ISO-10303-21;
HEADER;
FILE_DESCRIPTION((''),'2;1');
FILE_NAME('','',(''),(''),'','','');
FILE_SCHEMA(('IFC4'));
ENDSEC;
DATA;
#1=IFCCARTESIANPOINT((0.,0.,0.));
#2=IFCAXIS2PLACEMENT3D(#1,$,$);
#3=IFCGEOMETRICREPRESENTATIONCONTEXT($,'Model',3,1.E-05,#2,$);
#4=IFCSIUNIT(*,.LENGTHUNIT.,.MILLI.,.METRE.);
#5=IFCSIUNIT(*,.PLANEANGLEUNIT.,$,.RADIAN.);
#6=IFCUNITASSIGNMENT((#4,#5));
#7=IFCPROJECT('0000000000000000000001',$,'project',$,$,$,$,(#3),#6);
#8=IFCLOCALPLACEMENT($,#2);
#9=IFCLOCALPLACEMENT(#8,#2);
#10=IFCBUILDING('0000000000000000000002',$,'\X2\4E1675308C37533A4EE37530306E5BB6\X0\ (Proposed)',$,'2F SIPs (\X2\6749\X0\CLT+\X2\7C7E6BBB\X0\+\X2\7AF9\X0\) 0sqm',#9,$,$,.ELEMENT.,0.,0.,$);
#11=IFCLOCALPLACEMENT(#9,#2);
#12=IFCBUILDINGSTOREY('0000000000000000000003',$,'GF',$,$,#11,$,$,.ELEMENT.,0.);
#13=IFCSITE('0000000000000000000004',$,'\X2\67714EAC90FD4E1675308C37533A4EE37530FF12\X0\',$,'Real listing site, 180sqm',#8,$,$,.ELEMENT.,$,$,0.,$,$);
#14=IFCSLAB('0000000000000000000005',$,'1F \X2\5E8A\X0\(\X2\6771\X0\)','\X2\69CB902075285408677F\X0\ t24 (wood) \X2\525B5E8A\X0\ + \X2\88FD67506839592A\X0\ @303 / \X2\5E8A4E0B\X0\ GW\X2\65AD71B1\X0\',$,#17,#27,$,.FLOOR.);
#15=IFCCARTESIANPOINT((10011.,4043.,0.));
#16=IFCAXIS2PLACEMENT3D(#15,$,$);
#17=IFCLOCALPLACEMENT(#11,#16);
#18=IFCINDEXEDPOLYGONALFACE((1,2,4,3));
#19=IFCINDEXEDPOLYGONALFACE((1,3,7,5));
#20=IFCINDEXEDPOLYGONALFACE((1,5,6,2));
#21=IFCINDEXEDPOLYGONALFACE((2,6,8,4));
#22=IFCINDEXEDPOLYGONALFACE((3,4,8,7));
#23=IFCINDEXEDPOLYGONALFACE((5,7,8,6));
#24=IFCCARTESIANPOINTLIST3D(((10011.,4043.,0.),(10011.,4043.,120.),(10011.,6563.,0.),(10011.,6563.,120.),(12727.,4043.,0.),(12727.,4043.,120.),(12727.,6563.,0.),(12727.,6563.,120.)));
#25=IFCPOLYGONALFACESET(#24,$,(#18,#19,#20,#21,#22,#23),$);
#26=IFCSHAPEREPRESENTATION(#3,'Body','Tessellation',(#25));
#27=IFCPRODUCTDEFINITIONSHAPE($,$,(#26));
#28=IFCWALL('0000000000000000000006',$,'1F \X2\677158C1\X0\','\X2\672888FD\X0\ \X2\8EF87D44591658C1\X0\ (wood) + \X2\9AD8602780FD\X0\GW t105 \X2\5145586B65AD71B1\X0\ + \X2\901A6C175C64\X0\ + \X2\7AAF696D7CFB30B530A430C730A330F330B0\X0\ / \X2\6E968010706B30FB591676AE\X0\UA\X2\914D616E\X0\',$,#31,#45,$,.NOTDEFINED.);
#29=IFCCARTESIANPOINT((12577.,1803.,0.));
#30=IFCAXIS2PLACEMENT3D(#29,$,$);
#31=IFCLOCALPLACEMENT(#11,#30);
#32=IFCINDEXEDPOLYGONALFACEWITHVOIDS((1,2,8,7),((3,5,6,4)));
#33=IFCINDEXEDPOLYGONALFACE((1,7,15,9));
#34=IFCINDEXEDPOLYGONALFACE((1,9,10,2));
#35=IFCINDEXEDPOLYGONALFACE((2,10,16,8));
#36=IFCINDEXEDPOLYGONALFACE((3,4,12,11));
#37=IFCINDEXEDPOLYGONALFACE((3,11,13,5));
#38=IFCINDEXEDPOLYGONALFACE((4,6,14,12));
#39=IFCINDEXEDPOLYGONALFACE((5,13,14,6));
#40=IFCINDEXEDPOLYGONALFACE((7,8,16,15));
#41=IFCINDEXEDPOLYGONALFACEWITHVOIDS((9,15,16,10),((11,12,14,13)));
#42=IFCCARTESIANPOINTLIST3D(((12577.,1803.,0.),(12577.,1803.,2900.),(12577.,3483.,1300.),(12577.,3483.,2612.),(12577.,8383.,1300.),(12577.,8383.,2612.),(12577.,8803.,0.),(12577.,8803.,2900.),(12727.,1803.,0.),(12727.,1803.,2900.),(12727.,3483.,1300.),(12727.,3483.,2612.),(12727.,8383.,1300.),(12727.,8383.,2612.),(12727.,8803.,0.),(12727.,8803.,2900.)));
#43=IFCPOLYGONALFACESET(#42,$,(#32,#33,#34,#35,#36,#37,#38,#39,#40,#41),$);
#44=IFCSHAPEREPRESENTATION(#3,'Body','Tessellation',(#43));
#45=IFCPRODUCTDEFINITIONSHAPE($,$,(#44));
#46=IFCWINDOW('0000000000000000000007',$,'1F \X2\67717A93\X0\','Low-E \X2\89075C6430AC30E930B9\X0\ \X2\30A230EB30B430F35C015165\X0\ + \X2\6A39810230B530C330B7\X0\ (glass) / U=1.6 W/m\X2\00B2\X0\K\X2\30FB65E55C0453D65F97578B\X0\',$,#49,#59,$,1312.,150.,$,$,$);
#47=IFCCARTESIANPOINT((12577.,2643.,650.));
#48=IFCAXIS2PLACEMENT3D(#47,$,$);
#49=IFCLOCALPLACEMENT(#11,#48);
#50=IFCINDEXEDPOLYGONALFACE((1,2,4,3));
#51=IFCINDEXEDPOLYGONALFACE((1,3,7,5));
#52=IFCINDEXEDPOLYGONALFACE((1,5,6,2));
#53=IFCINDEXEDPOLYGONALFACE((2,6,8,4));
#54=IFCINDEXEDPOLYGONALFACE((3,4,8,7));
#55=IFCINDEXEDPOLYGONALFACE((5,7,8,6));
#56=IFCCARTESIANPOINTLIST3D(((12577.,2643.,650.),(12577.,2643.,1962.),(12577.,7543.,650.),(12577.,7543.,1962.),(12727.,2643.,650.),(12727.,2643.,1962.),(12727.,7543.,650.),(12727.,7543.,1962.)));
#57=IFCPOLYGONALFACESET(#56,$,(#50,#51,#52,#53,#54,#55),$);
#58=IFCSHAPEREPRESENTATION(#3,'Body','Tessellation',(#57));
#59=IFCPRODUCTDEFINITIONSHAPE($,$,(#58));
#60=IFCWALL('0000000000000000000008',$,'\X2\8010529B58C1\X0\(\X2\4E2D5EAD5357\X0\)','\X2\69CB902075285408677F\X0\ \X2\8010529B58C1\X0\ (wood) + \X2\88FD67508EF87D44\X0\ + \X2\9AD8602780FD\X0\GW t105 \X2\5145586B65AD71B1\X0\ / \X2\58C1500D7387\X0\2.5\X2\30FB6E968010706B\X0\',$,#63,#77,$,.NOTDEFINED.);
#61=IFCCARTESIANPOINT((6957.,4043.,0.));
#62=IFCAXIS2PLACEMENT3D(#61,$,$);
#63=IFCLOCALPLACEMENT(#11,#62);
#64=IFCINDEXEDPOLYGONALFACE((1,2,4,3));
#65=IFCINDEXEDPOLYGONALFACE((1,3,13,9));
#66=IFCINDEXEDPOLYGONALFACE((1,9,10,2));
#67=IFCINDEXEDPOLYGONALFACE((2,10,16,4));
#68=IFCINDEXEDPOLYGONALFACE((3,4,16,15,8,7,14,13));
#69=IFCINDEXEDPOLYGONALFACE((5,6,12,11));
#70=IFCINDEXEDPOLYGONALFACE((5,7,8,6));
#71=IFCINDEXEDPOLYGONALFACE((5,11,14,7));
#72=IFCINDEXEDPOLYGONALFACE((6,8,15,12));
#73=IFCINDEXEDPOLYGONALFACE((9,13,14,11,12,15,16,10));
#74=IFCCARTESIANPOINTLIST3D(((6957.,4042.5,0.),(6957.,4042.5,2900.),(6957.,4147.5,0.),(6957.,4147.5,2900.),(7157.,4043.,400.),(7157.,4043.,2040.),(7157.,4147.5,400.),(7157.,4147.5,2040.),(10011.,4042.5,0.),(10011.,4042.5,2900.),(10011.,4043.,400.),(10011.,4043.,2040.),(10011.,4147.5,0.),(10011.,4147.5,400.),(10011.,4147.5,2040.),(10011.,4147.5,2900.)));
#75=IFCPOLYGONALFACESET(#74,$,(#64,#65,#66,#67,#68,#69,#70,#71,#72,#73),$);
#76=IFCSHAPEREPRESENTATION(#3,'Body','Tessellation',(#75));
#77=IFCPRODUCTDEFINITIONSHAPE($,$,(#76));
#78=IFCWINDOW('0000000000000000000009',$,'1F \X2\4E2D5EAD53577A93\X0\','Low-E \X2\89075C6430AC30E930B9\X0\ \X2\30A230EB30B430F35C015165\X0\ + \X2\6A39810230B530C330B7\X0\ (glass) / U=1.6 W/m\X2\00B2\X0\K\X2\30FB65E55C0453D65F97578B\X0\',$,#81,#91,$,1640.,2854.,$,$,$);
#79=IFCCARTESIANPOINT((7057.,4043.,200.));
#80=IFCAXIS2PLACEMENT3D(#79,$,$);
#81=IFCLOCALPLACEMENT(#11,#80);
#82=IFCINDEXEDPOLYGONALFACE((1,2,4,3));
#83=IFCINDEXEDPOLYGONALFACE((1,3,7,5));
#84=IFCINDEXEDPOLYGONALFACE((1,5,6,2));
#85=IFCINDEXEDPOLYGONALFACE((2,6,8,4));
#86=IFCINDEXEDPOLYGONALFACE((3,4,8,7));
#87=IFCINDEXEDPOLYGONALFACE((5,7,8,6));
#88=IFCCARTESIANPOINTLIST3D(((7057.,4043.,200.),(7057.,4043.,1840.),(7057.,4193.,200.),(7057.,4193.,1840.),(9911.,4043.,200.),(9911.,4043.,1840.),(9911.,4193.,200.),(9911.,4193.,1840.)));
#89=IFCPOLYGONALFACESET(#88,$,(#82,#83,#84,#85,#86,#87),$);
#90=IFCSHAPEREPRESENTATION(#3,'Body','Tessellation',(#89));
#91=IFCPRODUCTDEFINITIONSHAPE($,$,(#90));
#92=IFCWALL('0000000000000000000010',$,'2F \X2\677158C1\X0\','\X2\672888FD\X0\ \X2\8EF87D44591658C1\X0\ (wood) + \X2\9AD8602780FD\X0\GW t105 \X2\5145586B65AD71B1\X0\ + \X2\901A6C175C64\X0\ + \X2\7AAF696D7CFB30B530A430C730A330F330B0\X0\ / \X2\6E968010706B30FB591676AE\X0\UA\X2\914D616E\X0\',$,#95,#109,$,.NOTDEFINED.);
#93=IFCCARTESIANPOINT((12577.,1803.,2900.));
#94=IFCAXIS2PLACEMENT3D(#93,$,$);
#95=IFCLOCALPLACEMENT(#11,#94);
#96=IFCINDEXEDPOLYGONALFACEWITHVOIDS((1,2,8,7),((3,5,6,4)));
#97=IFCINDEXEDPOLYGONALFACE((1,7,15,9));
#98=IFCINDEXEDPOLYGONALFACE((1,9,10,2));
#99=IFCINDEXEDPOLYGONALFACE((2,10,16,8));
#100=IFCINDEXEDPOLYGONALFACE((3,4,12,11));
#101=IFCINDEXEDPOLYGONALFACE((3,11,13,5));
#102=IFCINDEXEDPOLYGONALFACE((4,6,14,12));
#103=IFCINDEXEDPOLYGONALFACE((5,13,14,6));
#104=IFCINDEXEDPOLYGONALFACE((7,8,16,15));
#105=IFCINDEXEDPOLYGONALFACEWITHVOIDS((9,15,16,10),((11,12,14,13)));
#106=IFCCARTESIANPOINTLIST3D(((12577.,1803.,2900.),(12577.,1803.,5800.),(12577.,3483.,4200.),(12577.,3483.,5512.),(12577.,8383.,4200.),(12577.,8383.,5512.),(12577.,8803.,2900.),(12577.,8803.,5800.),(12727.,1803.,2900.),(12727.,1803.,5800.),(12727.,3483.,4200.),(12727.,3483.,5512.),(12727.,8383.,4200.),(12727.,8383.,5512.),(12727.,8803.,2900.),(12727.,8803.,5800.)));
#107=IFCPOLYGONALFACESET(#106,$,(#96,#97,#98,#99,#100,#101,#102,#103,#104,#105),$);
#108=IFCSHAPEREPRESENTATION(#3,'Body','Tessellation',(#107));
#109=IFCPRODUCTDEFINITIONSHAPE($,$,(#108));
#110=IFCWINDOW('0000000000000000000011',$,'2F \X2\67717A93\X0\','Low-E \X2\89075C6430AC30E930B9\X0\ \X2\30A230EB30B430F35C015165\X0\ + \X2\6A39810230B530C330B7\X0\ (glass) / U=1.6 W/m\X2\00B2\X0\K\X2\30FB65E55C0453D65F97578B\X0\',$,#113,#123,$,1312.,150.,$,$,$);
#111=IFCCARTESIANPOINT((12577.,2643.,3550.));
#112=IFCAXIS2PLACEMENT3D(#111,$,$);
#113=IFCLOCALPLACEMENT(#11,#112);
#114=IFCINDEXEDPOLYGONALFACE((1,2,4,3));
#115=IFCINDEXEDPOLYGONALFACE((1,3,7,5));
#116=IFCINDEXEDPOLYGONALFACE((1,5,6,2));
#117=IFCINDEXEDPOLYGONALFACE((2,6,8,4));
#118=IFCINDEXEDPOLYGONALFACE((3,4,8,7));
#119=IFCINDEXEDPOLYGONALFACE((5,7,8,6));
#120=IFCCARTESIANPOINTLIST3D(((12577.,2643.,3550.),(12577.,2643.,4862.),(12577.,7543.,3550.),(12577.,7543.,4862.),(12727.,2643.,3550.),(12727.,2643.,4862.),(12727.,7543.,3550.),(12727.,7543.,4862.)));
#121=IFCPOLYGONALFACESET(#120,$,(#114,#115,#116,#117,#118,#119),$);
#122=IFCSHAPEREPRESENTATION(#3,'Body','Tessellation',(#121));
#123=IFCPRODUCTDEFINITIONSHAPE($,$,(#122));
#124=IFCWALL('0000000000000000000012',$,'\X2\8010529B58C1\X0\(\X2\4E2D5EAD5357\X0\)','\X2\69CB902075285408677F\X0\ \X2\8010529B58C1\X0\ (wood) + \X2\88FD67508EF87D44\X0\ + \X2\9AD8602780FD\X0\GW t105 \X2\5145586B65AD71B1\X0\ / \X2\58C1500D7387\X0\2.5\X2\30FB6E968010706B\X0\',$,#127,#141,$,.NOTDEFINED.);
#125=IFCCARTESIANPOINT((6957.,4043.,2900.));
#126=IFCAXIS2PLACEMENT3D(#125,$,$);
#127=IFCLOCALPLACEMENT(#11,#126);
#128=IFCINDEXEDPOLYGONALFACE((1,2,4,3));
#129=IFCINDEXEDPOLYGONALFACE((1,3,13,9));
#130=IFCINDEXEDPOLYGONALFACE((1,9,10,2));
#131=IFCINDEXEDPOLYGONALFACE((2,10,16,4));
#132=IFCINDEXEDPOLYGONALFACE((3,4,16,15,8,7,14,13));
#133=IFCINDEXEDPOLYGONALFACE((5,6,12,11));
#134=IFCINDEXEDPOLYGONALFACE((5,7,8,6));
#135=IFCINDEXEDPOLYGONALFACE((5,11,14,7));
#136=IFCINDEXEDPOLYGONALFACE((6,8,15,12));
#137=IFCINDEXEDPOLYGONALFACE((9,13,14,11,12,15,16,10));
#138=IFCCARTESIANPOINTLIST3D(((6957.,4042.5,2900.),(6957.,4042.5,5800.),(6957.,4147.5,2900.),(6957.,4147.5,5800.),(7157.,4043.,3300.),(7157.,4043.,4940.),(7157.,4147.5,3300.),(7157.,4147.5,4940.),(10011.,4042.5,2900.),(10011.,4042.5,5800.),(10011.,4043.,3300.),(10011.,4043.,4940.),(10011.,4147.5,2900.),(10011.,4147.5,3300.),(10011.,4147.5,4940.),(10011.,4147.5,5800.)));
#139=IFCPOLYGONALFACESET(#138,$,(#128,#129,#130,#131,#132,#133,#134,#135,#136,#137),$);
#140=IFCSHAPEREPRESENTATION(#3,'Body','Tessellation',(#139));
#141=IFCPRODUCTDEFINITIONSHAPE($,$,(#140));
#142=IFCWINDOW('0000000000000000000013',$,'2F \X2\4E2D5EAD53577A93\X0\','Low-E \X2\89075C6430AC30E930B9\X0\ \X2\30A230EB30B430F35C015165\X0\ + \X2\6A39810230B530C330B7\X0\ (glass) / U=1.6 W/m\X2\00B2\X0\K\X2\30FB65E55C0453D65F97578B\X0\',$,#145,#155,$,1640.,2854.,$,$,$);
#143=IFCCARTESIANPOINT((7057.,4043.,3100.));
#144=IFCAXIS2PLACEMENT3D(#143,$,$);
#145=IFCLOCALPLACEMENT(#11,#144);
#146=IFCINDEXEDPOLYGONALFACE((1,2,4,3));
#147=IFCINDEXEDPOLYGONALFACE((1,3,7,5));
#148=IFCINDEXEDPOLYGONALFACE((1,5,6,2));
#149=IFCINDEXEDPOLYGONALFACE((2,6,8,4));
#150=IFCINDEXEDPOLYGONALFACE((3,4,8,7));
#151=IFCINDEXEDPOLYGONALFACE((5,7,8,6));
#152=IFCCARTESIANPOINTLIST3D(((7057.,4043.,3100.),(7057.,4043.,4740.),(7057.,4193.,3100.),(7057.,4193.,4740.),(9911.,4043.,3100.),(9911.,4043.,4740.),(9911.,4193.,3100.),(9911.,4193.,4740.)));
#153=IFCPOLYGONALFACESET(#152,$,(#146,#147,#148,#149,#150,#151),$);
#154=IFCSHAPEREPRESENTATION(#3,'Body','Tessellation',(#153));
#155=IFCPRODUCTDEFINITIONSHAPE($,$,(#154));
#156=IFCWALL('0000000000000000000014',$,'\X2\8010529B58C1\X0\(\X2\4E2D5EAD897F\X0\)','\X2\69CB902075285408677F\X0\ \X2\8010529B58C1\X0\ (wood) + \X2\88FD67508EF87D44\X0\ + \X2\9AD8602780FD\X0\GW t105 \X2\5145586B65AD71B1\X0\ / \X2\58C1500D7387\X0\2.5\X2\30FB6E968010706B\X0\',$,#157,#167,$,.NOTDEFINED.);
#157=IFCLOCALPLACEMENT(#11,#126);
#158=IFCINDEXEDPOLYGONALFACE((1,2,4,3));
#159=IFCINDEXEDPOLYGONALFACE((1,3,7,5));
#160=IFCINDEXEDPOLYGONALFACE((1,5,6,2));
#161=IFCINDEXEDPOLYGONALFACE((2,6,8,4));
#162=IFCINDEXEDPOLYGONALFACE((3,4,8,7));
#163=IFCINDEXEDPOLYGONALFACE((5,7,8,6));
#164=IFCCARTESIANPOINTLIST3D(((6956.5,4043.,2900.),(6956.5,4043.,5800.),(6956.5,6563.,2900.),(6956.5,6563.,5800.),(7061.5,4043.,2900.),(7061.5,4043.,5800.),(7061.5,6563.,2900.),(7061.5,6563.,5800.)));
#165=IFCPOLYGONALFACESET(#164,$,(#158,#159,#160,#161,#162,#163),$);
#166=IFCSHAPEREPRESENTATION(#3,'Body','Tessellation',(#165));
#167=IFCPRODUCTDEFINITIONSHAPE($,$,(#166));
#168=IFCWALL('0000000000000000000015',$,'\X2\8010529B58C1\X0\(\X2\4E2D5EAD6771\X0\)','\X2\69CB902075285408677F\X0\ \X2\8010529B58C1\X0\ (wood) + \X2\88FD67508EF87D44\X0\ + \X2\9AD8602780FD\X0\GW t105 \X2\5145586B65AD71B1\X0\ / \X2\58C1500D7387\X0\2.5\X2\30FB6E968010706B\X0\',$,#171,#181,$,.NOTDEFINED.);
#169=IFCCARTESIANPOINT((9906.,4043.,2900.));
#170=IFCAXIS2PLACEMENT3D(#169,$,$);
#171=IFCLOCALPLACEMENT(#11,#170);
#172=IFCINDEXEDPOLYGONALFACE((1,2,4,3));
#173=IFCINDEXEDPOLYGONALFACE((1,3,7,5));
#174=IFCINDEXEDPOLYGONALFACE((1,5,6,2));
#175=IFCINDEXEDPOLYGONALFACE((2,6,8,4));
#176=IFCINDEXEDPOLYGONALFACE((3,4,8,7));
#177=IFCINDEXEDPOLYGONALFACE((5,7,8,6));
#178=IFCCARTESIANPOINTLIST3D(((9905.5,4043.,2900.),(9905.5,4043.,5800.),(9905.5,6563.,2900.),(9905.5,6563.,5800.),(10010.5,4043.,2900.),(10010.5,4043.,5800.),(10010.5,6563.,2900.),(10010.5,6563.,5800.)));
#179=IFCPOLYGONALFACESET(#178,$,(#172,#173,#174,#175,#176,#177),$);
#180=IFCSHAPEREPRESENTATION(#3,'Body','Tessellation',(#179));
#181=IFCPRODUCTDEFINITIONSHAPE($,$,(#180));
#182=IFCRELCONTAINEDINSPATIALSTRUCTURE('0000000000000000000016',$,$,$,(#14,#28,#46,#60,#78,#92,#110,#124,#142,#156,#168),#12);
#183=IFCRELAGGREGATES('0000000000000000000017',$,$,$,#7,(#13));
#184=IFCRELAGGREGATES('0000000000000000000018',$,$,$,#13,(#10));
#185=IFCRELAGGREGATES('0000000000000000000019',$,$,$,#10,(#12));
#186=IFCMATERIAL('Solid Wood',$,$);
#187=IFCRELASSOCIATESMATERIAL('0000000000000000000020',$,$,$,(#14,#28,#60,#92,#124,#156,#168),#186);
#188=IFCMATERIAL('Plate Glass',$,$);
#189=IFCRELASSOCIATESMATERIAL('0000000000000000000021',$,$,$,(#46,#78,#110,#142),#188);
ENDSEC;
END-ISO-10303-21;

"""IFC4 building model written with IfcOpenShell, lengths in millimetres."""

from ifc_helpers import new_model, si_unit, frame, frame_2d, origin, place, context, project, spatial, rectangle, extrude, material, element, fill, save


model = new_model("IFC4")

# Units and contexts
model_context = context("Model", 3, precision=1e-05, world=origin())
ifc_project = project(units=[si_unit("LENGTHUNIT", "METRE", prefix="MILLI"), si_unit("PLANEANGLEUNIT", "RADIAN")], contexts=[model_context])

# Site, building, storey
site_placement = place(None, origin())
site = spatial("IfcSite", under=ifc_project, at=site_placement, Name="東京都世田谷区代田２", ObjectType="Real listing site, 180sqm", CompositionType="ELEMENT", RefElevation=0.0)
building_placement = place(site_placement, origin())
building = spatial("IfcBuilding", under=site, at=building_placement, Name="世田谷区代田の家 (Proposed)", ObjectType="2F SIPs (杉CLT+籾殻+竹) 0sqm", CompositionType="ELEMENT", ElevationOfRefHeight=0.0, ElevationOfTerrain=0.0)
storey_placement = place(building_placement, origin())
storey = spatial("IfcBuildingStorey", under=building, at=storey_placement, Name="GF", CompositionType="ELEMENT", Elevation=0.0)

# Slab
ifc_material_1 = material(Name="Solid Wood")
slab_placement = place(storey_placement, frame((10011.0, 4043.0, 0.0)))
element("IfcSlab", 1, at=slab_placement, inside=storey, material=ifc_material_1, Name="1F 床(東)", Description="構造用合板 t24 (wood) 剛床 + 製材根太 @303 / 床下 GW断熱", PredefinedType="FLOOR", context=model_context, shape_type="SweptSolid", body=[
    extrude(rectangle(XDim=2716.0, YDim=2520.0, at=frame_2d((1358.0, 1260.0))), frame((10011.0, 4043.0, 0.0)), (0.0, 0.0, 1.0), 120.0),
])

# Walls, openings, windows
wall_1_placement = place(storey_placement, frame((12577.0, 1803.0, 0.0)))
wall_1 = element("IfcWall", 2, at=wall_1_placement, inside=storey, material=ifc_material_1, Name="1F 東壁", Description="木製 軸組外壁 (wood) + 高性能GW t105 充填断熱 + 通気層 + 窯業系サイディング / 準耐火・外皮UA配慮", PredefinedType="NOTDEFINED", context=model_context, shape_type="SweptSolid", body=[
    extrude(rectangle(XDim=150.0, YDim=7000.0, at=frame_2d((75.0, 3500.0))), frame((12577.0, 1803.0, 0.0)), (0.0, 0.0, 1.0), 2900.0),
])
opening_1_placement = place(storey_placement, frame((12577.0, 2643.0, 650.0)))
opening_1 = element("IfcOpeningElement", 3, at=opening_1_placement, cuts=wall_1, PredefinedType="NOTDEFINED", context=model_context, shape_type="SweptSolid", body=[
    extrude(rectangle(XDim=150.0, YDim=4900.0, at=frame_2d((75.0, 2450.0))), frame((12577.0, 2643.0, 650.0)), (0.0, 0.0, 1.0), 1312.0),
])
ifc_material_2 = material(Name="Plate Glass")
window_1_placement = place(storey_placement, frame((12577.0, 2643.0, 650.0)))
window_1 = element("IfcWindow", 4, at=window_1_placement, inside=storey, material=ifc_material_2, Name="1F 東窓", Description="Low-E 複層ガラス アルゴン封入 + 樹脂サッシ (glass) / U=1.6 W/m²K・日射取得型", OverallHeight=1312.0, OverallWidth=150.0, context=model_context, shape_type="SweptSolid", body=[
    extrude(rectangle(XDim=150.0, YDim=4900.0, at=frame_2d((75.0, 2450.0))), frame((12577.0, 2643.0, 650.0)), (0.0, 0.0, 1.0), 1312.0),
])
fill(opening_1, window_1)
wall_2_placement = place(storey_placement, frame((6957.0, 4043.0, 0.0)))
wall_2 = element("IfcWall", 5, at=wall_2_placement, inside=storey, material=ifc_material_1, Name="耐力壁(中庭南)", Description="構造用合板 耐力壁 (wood) + 製材軸組 + 高性能GW t105 充填断熱 / 壁倍率2.5・準耐火", PredefinedType="NOTDEFINED", context=model_context, shape_type="SweptSolid", body=[
    extrude(rectangle(XDim=3054.0, YDim=105.0, at=frame_2d((1527.0, 52.0))), frame((6957.0, 4043.0, 0.0)), (0.0, 0.0, 1.0), 2900.0),
])
opening_2_placement = place(storey_placement, frame((7057.0, 4043.0, 200.0)))
opening_2 = element("IfcOpeningElement", 6, at=opening_2_placement, cuts=wall_2, PredefinedType="NOTDEFINED", context=model_context, shape_type="SweptSolid", body=[
    extrude(rectangle(XDim=2854.0, YDim=150.0, at=frame_2d((1427.0, 75.0))), frame((7057.0, 4043.0, 200.0)), (0.0, 0.0, 1.0), 1640.0),
])
window_2_placement = place(storey_placement, frame((7057.0, 4043.0, 200.0)))
window_2 = element("IfcWindow", 7, at=window_2_placement, inside=storey, material=ifc_material_2, Name="1F 中庭南窓", Description="Low-E 複層ガラス アルゴン封入 + 樹脂サッシ (glass) / U=1.6 W/m²K・日射取得型", OverallHeight=1640.0, OverallWidth=2854.0, context=model_context, shape_type="SweptSolid", body=[
    extrude(rectangle(XDim=2854.0, YDim=150.0, at=frame_2d((1427.0, 75.0))), frame((7057.0, 4043.0, 200.0)), (0.0, 0.0, 1.0), 1640.0),
])
fill(opening_2, window_2)

# Walls, openings, windows
wall_3_placement = place(storey_placement, frame((12577.0, 1803.0, 2900.0)))
wall_3 = element("IfcWall", 8, at=wall_3_placement, inside=storey, material=ifc_material_1, Name="2F 東壁", Description="木製 軸組外壁 (wood) + 高性能GW t105 充填断熱 + 通気層 + 窯業系サイディング / 準耐火・外皮UA配慮", PredefinedType="NOTDEFINED", context=model_context, shape_type="SweptSolid", body=[
    extrude(rectangle(XDim=150.0, YDim=7000.0, at=frame_2d((75.0, 3500.0))), frame((12577.0, 1803.0, 2900.0)), (0.0, 0.0, 1.0), 2900.0),
])
opening_3_placement = place(storey_placement, frame((12577.0, 2643.0, 3550.0)))
opening_3 = element("IfcOpeningElement", 9, at=opening_3_placement, cuts=wall_3, PredefinedType="NOTDEFINED", context=model_context, shape_type="SweptSolid", body=[
    extrude(rectangle(XDim=150.0, YDim=4900.0, at=frame_2d((75.0, 2450.0))), frame((12577.0, 2643.0, 3550.0)), (0.0, 0.0, 1.0), 1312.0),
])
window_3_placement = place(storey_placement, frame((12577.0, 2643.0, 3550.0)))
window_3 = element("IfcWindow", 10, at=window_3_placement, inside=storey, material=ifc_material_2, Name="2F 東窓", Description="Low-E 複層ガラス アルゴン封入 + 樹脂サッシ (glass) / U=1.6 W/m²K・日射取得型", OverallHeight=1312.0, OverallWidth=150.0, context=model_context, shape_type="SweptSolid", body=[
    extrude(rectangle(XDim=150.0, YDim=4900.0, at=frame_2d((75.0, 2450.0))), frame((12577.0, 2643.0, 3550.0)), (0.0, 0.0, 1.0), 1312.0),
])
fill(opening_3, window_3)
wall_4_placement = place(storey_placement, frame((6957.0, 4043.0, 2900.0)))
wall_4 = element("IfcWall", 11, at=wall_4_placement, inside=storey, material=ifc_material_1, Name="耐力壁(中庭南)", Description="構造用合板 耐力壁 (wood) + 製材軸組 + 高性能GW t105 充填断熱 / 壁倍率2.5・準耐火", PredefinedType="NOTDEFINED", context=model_context, shape_type="SweptSolid", body=[
    extrude(rectangle(XDim=3054.0, YDim=105.0, at=frame_2d((1527.0, 52.0))), frame((6957.0, 4043.0, 2900.0)), (0.0, 0.0, 1.0), 2900.0),
])
opening_4_placement = place(storey_placement, frame((7057.0, 4043.0, 3100.0)))
opening_4 = element("IfcOpeningElement", 12, at=opening_4_placement, cuts=wall_4, PredefinedType="NOTDEFINED", context=model_context, shape_type="SweptSolid", body=[
    extrude(rectangle(XDim=2854.0, YDim=150.0, at=frame_2d((1427.0, 75.0))), frame((7057.0, 4043.0, 3100.0)), (0.0, 0.0, 1.0), 1640.0),
])
window_4_placement = place(storey_placement, frame((7057.0, 4043.0, 3100.0)))
window_4 = element("IfcWindow", 13, at=window_4_placement, inside=storey, material=ifc_material_2, Name="2F 中庭南窓", Description="Low-E 複層ガラス アルゴン封入 + 樹脂サッシ (glass) / U=1.6 W/m²K・日射取得型", OverallHeight=1640.0, OverallWidth=2854.0, context=model_context, shape_type="SweptSolid", body=[
    extrude(rectangle(XDim=2854.0, YDim=150.0, at=frame_2d((1427.0, 75.0))), frame((7057.0, 4043.0, 3100.0)), (0.0, 0.0, 1.0), 1640.0),
])
fill(opening_4, window_4)

# Walls
wall_5_placement = place(storey_placement, frame((6957.0, 4043.0, 2900.0)))
element("IfcWall", 14, at=wall_5_placement, inside=storey, material=ifc_material_1, Name="耐力壁(中庭西)", Description="構造用合板 耐力壁 (wood) + 製材軸組 + 高性能GW t105 充填断熱 / 壁倍率2.5・準耐火", PredefinedType="NOTDEFINED", context=model_context, shape_type="SweptSolid", body=[
    extrude(rectangle(XDim=105.0, YDim=2520.0, at=frame_2d((52.0, 1260.0))), frame((6957.0, 4043.0, 2900.0)), (0.0, 0.0, 1.0), 2900.0),
])
wall_6_placement = place(storey_placement, frame((9906.0, 4043.0, 2900.0)))
element("IfcWall", 15, at=wall_6_placement, inside=storey, material=ifc_material_1, Name="耐力壁(中庭東)", Description="構造用合板 耐力壁 (wood) + 製材軸組 + 高性能GW t105 充填断熱 / 壁倍率2.5・準耐火", PredefinedType="NOTDEFINED", context=model_context, shape_type="SweptSolid", body=[
    extrude(rectangle(XDim=105.0, YDim=2520.0, at=frame_2d((52.0, 1260.0))), frame((9906.0, 4043.0, 2900.0)), (0.0, 0.0, 1.0), 2900.0),
])

save(model, "model.ifc")
